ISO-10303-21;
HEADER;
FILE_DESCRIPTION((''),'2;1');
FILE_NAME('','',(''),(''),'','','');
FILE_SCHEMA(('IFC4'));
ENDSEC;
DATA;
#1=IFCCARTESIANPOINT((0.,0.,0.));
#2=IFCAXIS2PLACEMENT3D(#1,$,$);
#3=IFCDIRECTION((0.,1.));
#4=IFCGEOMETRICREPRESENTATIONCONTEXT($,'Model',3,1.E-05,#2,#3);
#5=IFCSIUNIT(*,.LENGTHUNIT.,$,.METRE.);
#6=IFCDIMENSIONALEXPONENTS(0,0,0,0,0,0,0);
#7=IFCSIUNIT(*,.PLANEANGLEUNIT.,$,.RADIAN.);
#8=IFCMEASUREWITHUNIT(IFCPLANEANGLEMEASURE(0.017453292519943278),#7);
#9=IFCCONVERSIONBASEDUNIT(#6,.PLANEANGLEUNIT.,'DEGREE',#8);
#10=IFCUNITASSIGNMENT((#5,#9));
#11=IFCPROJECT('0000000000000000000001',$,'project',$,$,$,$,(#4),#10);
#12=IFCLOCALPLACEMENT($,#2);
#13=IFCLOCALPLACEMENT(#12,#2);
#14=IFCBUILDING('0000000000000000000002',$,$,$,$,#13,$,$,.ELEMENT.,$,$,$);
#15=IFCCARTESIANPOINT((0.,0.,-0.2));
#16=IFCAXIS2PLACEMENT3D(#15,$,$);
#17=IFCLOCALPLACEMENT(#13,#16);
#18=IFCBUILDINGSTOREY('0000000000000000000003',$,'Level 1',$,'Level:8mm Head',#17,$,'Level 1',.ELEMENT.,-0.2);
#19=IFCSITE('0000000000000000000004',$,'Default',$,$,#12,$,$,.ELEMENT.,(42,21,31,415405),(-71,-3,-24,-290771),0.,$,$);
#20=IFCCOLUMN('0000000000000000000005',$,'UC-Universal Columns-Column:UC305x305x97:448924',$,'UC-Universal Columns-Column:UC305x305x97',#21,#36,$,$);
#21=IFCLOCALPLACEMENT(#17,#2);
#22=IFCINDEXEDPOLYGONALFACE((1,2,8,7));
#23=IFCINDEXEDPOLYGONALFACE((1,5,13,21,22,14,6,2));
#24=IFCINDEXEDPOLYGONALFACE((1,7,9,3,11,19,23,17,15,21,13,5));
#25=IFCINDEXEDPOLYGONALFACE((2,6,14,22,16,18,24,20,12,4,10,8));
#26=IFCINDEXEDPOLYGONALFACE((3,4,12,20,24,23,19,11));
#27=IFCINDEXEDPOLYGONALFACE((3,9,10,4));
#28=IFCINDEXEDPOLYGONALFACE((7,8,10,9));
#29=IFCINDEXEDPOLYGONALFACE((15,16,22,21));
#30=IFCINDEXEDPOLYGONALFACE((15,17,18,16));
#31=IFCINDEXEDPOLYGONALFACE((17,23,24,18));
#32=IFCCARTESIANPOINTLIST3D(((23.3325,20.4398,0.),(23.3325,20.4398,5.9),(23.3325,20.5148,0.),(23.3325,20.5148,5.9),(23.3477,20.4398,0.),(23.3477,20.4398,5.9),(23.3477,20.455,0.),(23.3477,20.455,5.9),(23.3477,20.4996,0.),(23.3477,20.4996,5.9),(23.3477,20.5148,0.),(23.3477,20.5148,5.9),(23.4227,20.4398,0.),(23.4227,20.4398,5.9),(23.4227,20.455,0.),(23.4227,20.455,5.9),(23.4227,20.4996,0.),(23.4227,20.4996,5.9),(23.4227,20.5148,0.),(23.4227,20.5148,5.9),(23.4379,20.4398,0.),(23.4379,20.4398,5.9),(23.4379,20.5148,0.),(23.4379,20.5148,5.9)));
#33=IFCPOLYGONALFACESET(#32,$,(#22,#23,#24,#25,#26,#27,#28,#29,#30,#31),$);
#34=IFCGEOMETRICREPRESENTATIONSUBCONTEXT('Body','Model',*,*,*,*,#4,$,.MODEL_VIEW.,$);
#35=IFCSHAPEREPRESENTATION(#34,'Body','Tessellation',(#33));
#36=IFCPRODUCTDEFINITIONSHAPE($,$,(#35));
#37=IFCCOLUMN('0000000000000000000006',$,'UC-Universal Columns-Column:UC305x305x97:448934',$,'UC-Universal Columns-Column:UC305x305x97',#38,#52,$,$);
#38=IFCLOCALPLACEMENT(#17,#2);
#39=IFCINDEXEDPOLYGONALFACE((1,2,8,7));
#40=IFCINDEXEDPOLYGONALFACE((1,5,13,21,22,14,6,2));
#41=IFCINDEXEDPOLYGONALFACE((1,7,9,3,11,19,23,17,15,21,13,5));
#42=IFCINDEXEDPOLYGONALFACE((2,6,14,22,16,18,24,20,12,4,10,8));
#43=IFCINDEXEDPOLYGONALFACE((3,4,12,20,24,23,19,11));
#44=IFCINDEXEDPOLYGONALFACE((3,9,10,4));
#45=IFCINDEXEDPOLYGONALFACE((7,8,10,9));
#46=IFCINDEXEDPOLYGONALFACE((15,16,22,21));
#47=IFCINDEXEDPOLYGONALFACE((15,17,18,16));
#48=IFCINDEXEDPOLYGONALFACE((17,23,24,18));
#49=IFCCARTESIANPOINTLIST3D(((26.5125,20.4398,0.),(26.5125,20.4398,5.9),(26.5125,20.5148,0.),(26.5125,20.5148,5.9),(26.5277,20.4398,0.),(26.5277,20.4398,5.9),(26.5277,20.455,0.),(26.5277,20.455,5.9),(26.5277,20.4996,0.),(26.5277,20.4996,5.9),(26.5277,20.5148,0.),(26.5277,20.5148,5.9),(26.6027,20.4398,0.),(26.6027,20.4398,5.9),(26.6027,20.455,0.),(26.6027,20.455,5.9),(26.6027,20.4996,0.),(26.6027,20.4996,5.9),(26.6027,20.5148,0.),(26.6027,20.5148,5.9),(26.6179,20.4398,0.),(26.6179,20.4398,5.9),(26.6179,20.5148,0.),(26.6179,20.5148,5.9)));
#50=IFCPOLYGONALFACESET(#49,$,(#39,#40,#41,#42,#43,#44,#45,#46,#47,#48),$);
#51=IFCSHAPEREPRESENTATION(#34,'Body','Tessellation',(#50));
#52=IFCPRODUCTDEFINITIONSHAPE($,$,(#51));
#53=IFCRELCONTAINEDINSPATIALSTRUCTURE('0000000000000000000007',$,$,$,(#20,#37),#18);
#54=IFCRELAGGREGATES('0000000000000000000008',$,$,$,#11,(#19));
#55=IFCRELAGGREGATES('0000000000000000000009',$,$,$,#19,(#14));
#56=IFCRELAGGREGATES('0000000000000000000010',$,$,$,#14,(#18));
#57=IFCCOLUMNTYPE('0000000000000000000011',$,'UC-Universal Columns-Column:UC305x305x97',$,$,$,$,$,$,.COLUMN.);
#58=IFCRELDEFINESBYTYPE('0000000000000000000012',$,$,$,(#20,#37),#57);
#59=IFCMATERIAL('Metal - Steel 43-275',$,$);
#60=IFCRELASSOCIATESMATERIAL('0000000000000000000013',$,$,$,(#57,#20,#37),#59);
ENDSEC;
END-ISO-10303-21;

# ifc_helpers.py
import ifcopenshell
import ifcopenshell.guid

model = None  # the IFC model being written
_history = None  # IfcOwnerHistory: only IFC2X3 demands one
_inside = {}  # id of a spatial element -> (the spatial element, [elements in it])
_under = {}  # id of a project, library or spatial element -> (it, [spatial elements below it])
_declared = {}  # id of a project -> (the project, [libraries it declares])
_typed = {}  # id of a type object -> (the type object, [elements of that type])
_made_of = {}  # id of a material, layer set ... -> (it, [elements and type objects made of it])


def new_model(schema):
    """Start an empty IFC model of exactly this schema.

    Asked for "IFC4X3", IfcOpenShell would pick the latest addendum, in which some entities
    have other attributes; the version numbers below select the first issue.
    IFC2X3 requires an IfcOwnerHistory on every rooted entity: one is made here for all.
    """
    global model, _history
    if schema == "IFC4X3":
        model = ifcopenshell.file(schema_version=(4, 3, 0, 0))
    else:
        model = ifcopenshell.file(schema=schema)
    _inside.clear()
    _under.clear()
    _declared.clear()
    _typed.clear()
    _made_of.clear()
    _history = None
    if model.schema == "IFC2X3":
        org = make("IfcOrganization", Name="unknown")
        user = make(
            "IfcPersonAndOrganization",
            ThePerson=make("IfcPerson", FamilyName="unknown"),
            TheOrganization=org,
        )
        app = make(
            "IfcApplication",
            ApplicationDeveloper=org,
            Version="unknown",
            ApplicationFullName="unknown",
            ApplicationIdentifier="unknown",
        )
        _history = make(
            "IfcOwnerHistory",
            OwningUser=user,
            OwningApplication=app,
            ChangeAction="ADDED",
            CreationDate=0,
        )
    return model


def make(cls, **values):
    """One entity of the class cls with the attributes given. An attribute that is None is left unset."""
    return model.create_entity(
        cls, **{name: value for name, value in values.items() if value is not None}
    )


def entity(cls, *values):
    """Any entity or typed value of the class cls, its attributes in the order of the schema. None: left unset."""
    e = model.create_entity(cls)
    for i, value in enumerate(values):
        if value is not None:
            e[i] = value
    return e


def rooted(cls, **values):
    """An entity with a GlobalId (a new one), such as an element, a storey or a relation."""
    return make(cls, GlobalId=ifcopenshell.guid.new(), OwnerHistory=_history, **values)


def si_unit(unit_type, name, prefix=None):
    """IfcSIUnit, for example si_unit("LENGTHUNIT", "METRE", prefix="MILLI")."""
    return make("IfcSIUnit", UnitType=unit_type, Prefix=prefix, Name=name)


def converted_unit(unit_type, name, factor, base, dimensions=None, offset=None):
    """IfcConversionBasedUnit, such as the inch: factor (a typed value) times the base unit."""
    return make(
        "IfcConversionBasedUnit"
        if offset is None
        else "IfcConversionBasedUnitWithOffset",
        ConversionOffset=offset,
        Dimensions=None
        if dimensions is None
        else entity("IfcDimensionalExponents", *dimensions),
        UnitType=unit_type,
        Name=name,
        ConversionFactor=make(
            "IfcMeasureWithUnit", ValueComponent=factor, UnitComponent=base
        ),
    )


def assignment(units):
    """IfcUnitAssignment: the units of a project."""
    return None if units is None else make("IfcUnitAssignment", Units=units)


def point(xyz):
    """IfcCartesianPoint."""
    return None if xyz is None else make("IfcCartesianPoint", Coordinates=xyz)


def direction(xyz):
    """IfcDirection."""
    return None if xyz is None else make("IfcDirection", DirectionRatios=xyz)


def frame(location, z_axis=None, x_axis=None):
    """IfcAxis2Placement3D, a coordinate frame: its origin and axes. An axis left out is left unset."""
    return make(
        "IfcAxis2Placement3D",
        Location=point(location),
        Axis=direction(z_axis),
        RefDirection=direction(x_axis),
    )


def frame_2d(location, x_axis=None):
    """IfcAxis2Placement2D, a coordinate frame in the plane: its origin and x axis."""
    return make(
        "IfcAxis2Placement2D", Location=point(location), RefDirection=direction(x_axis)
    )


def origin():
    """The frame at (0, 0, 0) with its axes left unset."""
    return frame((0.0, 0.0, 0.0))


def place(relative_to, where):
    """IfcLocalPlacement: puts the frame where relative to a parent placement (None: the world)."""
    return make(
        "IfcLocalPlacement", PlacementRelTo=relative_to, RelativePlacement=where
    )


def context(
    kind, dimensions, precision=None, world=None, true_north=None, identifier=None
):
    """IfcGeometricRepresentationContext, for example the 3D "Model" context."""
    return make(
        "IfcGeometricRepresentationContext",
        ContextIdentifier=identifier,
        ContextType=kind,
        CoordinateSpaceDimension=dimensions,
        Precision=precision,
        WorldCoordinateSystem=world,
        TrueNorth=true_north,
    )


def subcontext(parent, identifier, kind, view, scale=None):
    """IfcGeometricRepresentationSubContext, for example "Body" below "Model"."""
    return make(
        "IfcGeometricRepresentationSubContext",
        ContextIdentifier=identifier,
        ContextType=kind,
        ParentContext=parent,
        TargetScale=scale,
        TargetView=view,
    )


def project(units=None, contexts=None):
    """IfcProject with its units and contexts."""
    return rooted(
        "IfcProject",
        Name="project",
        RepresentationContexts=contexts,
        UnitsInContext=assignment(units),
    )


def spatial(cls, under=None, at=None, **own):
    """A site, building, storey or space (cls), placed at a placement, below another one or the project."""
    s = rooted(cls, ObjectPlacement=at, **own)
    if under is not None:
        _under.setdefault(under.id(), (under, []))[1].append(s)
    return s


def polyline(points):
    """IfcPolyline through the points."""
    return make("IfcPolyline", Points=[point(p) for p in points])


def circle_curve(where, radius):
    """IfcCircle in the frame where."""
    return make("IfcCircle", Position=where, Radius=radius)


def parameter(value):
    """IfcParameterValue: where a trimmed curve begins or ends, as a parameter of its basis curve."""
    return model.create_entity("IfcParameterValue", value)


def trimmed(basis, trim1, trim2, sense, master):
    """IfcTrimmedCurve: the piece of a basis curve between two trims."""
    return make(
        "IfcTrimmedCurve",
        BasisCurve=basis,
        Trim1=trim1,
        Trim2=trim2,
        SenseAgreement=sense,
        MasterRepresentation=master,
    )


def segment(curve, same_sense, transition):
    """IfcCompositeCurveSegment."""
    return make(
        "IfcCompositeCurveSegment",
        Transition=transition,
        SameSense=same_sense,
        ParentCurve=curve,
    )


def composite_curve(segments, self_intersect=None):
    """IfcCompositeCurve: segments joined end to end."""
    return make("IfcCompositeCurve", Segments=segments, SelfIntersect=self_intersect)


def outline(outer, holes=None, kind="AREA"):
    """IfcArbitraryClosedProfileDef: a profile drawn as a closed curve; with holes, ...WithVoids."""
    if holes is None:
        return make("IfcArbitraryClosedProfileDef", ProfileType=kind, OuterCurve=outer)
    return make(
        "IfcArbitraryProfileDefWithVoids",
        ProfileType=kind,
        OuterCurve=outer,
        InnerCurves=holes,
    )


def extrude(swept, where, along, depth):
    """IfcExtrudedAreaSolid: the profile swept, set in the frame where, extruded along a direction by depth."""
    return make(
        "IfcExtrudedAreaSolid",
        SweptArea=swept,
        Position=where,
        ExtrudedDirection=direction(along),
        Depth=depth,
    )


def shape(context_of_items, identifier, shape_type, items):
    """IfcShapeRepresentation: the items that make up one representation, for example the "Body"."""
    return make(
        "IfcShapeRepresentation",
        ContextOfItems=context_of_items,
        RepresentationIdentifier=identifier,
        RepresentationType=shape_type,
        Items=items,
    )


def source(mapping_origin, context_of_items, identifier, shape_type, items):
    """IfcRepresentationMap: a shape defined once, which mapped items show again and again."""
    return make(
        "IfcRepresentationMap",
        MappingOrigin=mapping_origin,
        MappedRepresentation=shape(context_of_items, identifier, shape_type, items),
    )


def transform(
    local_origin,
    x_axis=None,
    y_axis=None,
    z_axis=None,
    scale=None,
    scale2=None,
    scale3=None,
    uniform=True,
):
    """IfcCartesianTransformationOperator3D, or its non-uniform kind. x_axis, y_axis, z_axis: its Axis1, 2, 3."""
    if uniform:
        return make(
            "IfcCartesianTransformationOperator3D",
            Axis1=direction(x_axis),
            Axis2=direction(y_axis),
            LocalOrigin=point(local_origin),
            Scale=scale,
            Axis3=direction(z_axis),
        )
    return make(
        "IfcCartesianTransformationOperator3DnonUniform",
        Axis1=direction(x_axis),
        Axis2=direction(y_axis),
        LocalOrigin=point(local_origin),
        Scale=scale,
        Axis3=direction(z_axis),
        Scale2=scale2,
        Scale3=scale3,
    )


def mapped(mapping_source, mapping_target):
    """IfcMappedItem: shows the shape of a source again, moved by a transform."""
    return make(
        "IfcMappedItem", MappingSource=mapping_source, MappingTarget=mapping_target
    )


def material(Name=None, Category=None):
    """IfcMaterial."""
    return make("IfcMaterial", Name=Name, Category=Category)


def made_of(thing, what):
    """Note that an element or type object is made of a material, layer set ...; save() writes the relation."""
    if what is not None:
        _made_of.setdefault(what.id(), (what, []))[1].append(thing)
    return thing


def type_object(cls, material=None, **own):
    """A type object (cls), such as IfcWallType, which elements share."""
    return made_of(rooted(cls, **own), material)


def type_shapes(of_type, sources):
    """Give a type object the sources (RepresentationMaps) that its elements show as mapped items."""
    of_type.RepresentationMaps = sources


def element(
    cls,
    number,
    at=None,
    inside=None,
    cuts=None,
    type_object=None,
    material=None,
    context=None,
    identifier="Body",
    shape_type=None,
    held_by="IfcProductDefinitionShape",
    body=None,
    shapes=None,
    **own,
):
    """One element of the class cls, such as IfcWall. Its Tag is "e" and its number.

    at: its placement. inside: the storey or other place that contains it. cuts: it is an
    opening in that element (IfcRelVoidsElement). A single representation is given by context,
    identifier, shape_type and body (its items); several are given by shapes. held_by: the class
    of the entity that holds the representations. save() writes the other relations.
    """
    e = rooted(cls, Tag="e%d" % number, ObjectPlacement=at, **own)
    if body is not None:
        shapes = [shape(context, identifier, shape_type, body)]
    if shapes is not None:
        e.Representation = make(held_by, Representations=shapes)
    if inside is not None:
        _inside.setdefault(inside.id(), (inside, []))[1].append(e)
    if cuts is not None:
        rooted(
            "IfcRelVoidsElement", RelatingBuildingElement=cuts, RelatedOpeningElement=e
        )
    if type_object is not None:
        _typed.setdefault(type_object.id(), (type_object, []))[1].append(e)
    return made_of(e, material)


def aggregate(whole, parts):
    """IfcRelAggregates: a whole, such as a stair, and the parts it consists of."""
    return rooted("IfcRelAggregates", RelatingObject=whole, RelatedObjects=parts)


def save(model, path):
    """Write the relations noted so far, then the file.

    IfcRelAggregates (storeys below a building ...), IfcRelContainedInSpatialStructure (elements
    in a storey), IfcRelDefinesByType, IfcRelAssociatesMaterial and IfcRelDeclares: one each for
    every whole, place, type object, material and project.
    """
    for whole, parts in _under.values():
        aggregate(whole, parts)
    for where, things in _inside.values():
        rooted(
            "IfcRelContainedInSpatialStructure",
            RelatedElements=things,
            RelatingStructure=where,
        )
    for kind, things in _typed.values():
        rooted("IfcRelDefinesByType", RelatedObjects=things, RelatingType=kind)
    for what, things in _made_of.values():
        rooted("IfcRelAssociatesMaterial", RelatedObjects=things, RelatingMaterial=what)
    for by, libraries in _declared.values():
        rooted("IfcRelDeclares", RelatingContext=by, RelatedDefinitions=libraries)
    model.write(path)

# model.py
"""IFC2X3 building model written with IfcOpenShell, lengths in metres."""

from ifc_helpers import new_model, entity, si_unit, converted_unit, direction, frame, frame_2d, origin, place, context, subcontext, project, spatial, polyline, circle_curve, parameter, trimmed, segment, composite_curve, outline, extrude, source, transform, mapped, material, type_object, type_shapes, element, save


model = new_model("IFC2X3")

# Units and contexts
model_context = context("Model", 3, precision=1e-05, world=origin(), true_north=direction((0.0, 1.0)))
body_context = subcontext(model_context, "Body", "Model", "MODEL_VIEW")
ifc_project = project(units=[si_unit("LENGTHUNIT", "METRE"), converted_unit("PLANEANGLEUNIT", "DEGREE", entity("IfcPlaneAngleMeasure", 0.017453292519943278), si_unit("PLANEANGLEUNIT", "RADIAN"), dimensions=[0, 0, 0, 0, 0, 0, 0])], contexts=[model_context])

# Site, building, storey
site_placement = place(None, origin())
site = spatial("IfcSite", under=ifc_project, at=site_placement, Name="Default", CompositionType="ELEMENT", RefLatitude=(42, 21, 31, 415405), RefLongitude=(-71, -3, -24, -290771), RefElevation=0.0)
building_placement = place(site_placement, origin())
building = spatial("IfcBuilding", under=site, at=building_placement, CompositionType="ELEMENT")
storey_placement = place(building_placement, frame((0.0, 0.0, -0.2)))
storey = spatial("IfcBuildingStorey", under=building, at=storey_placement, Name="Level 1", ObjectType="Level:8mm Head", LongName="Level 1", CompositionType="ELEMENT", Elevation=-0.2)

# Columns
ifc_material = material(Name="Metal - Steel 43-275")
column_type = type_object("IfcColumnType", Name="UC-Universal Columns-Column:UC305x305x97", PredefinedType="COLUMN", material=ifc_material)
shared_shape = source(origin(), body_context, "Body", "SweptSolid", [
    extrude(outline(composite_curve([segment(polyline([(-0.0375, -0.0375), (0.0375, -0.0375)]), True, "CONTINUOUS"), segment(polyline([(0.0375, -0.0375), (0.0527, -0.0375)]), True, "CONTINUOUS"), segment(trimmed(circle_curve(frame_2d((0.0527, -0.0223), x_axis=(-1.0, 0.0)), 0.0152), [parameter(0.0)], [parameter(90.0)], True, "PARAMETER"), False, "CONTINUOUS"), segment(polyline([(0.0375, -0.0223), (0.0375, 0.0223)]), True, "CONTINUOUS"), segment(trimmed(circle_curve(frame_2d((0.0527, 0.0223), x_axis=(-1.0, 0.0)), 0.0152), [parameter(270.0)], [parameter(0.0)], True, "PARAMETER"), False, "CONTINUOUS"), segment(polyline([(0.0527, 0.0375), (0.0375, 0.0375)]), True, "CONTINUOUS"), segment(polyline([(0.0375, 0.0375), (-0.0375, 0.0375)]), True, "CONTINUOUS"), segment(polyline([(-0.0375, 0.0375), (-0.0527, 0.0375)]), True, "CONTINUOUS"), segment(trimmed(circle_curve(frame_2d((-0.0527, 0.0223), x_axis=(-1.0, 0.0)), 0.0152), [parameter(180.0)], [parameter(270.0)], True, "PARAMETER"), False, "CONTINUOUS"), segment(polyline([(-0.0375, 0.0223), (-0.0375, -0.0223)]), True, "CONTINUOUS"), segment(trimmed(circle_curve(frame_2d((-0.0527, -0.0223), x_axis=(-1.0, 0.0)), 0.0152), [parameter(90.0)], [parameter(180.0)], True, "PARAMETER"), False, "CONTINUOUS"), segment(polyline([(-0.0527, -0.0375), (-0.0375, -0.0375)]), True, "CONTINUOUS")], self_intersect=False)), frame((0.0, 0.0, -0.2), z_axis=(0.0, 0.0, 1.0), x_axis=(-1.0, 0.0, 0.0)), (0.0, 0.0, 1.0), 5.9),
])
type_shapes(column_type, [shared_shape])
for number, where, z_axis, x_axis, name in (
    (1, (23.3852, 20.4773, 0.2), (0.0, 0.0, 1.0), (-1.0, 0.0, 0.0), "UC-Universal Columns-Column:UC305x305x97:448924"),
    (2, (26.5652, 20.4773, 0.2), (0.0, 0.0, 1.0), (-1.0, 0.0, 0.0), "UC-Universal Columns-Column:UC305x305x97:448934"),
):
    element("IfcColumn", number, at=place(storey_placement, frame(where, z_axis=z_axis, x_axis=x_axis)), inside=storey, type_object=column_type, material=ifc_material, Name=name, ObjectType="UC-Universal Columns-Column:UC305x305x97", context=body_context, shape_type="MappedRepresentation", body=[
        mapped(shared_shape, transform((0.0, 0.0, 0.0), scale=1.0)),
    ])

save(model, "model.ifc")
